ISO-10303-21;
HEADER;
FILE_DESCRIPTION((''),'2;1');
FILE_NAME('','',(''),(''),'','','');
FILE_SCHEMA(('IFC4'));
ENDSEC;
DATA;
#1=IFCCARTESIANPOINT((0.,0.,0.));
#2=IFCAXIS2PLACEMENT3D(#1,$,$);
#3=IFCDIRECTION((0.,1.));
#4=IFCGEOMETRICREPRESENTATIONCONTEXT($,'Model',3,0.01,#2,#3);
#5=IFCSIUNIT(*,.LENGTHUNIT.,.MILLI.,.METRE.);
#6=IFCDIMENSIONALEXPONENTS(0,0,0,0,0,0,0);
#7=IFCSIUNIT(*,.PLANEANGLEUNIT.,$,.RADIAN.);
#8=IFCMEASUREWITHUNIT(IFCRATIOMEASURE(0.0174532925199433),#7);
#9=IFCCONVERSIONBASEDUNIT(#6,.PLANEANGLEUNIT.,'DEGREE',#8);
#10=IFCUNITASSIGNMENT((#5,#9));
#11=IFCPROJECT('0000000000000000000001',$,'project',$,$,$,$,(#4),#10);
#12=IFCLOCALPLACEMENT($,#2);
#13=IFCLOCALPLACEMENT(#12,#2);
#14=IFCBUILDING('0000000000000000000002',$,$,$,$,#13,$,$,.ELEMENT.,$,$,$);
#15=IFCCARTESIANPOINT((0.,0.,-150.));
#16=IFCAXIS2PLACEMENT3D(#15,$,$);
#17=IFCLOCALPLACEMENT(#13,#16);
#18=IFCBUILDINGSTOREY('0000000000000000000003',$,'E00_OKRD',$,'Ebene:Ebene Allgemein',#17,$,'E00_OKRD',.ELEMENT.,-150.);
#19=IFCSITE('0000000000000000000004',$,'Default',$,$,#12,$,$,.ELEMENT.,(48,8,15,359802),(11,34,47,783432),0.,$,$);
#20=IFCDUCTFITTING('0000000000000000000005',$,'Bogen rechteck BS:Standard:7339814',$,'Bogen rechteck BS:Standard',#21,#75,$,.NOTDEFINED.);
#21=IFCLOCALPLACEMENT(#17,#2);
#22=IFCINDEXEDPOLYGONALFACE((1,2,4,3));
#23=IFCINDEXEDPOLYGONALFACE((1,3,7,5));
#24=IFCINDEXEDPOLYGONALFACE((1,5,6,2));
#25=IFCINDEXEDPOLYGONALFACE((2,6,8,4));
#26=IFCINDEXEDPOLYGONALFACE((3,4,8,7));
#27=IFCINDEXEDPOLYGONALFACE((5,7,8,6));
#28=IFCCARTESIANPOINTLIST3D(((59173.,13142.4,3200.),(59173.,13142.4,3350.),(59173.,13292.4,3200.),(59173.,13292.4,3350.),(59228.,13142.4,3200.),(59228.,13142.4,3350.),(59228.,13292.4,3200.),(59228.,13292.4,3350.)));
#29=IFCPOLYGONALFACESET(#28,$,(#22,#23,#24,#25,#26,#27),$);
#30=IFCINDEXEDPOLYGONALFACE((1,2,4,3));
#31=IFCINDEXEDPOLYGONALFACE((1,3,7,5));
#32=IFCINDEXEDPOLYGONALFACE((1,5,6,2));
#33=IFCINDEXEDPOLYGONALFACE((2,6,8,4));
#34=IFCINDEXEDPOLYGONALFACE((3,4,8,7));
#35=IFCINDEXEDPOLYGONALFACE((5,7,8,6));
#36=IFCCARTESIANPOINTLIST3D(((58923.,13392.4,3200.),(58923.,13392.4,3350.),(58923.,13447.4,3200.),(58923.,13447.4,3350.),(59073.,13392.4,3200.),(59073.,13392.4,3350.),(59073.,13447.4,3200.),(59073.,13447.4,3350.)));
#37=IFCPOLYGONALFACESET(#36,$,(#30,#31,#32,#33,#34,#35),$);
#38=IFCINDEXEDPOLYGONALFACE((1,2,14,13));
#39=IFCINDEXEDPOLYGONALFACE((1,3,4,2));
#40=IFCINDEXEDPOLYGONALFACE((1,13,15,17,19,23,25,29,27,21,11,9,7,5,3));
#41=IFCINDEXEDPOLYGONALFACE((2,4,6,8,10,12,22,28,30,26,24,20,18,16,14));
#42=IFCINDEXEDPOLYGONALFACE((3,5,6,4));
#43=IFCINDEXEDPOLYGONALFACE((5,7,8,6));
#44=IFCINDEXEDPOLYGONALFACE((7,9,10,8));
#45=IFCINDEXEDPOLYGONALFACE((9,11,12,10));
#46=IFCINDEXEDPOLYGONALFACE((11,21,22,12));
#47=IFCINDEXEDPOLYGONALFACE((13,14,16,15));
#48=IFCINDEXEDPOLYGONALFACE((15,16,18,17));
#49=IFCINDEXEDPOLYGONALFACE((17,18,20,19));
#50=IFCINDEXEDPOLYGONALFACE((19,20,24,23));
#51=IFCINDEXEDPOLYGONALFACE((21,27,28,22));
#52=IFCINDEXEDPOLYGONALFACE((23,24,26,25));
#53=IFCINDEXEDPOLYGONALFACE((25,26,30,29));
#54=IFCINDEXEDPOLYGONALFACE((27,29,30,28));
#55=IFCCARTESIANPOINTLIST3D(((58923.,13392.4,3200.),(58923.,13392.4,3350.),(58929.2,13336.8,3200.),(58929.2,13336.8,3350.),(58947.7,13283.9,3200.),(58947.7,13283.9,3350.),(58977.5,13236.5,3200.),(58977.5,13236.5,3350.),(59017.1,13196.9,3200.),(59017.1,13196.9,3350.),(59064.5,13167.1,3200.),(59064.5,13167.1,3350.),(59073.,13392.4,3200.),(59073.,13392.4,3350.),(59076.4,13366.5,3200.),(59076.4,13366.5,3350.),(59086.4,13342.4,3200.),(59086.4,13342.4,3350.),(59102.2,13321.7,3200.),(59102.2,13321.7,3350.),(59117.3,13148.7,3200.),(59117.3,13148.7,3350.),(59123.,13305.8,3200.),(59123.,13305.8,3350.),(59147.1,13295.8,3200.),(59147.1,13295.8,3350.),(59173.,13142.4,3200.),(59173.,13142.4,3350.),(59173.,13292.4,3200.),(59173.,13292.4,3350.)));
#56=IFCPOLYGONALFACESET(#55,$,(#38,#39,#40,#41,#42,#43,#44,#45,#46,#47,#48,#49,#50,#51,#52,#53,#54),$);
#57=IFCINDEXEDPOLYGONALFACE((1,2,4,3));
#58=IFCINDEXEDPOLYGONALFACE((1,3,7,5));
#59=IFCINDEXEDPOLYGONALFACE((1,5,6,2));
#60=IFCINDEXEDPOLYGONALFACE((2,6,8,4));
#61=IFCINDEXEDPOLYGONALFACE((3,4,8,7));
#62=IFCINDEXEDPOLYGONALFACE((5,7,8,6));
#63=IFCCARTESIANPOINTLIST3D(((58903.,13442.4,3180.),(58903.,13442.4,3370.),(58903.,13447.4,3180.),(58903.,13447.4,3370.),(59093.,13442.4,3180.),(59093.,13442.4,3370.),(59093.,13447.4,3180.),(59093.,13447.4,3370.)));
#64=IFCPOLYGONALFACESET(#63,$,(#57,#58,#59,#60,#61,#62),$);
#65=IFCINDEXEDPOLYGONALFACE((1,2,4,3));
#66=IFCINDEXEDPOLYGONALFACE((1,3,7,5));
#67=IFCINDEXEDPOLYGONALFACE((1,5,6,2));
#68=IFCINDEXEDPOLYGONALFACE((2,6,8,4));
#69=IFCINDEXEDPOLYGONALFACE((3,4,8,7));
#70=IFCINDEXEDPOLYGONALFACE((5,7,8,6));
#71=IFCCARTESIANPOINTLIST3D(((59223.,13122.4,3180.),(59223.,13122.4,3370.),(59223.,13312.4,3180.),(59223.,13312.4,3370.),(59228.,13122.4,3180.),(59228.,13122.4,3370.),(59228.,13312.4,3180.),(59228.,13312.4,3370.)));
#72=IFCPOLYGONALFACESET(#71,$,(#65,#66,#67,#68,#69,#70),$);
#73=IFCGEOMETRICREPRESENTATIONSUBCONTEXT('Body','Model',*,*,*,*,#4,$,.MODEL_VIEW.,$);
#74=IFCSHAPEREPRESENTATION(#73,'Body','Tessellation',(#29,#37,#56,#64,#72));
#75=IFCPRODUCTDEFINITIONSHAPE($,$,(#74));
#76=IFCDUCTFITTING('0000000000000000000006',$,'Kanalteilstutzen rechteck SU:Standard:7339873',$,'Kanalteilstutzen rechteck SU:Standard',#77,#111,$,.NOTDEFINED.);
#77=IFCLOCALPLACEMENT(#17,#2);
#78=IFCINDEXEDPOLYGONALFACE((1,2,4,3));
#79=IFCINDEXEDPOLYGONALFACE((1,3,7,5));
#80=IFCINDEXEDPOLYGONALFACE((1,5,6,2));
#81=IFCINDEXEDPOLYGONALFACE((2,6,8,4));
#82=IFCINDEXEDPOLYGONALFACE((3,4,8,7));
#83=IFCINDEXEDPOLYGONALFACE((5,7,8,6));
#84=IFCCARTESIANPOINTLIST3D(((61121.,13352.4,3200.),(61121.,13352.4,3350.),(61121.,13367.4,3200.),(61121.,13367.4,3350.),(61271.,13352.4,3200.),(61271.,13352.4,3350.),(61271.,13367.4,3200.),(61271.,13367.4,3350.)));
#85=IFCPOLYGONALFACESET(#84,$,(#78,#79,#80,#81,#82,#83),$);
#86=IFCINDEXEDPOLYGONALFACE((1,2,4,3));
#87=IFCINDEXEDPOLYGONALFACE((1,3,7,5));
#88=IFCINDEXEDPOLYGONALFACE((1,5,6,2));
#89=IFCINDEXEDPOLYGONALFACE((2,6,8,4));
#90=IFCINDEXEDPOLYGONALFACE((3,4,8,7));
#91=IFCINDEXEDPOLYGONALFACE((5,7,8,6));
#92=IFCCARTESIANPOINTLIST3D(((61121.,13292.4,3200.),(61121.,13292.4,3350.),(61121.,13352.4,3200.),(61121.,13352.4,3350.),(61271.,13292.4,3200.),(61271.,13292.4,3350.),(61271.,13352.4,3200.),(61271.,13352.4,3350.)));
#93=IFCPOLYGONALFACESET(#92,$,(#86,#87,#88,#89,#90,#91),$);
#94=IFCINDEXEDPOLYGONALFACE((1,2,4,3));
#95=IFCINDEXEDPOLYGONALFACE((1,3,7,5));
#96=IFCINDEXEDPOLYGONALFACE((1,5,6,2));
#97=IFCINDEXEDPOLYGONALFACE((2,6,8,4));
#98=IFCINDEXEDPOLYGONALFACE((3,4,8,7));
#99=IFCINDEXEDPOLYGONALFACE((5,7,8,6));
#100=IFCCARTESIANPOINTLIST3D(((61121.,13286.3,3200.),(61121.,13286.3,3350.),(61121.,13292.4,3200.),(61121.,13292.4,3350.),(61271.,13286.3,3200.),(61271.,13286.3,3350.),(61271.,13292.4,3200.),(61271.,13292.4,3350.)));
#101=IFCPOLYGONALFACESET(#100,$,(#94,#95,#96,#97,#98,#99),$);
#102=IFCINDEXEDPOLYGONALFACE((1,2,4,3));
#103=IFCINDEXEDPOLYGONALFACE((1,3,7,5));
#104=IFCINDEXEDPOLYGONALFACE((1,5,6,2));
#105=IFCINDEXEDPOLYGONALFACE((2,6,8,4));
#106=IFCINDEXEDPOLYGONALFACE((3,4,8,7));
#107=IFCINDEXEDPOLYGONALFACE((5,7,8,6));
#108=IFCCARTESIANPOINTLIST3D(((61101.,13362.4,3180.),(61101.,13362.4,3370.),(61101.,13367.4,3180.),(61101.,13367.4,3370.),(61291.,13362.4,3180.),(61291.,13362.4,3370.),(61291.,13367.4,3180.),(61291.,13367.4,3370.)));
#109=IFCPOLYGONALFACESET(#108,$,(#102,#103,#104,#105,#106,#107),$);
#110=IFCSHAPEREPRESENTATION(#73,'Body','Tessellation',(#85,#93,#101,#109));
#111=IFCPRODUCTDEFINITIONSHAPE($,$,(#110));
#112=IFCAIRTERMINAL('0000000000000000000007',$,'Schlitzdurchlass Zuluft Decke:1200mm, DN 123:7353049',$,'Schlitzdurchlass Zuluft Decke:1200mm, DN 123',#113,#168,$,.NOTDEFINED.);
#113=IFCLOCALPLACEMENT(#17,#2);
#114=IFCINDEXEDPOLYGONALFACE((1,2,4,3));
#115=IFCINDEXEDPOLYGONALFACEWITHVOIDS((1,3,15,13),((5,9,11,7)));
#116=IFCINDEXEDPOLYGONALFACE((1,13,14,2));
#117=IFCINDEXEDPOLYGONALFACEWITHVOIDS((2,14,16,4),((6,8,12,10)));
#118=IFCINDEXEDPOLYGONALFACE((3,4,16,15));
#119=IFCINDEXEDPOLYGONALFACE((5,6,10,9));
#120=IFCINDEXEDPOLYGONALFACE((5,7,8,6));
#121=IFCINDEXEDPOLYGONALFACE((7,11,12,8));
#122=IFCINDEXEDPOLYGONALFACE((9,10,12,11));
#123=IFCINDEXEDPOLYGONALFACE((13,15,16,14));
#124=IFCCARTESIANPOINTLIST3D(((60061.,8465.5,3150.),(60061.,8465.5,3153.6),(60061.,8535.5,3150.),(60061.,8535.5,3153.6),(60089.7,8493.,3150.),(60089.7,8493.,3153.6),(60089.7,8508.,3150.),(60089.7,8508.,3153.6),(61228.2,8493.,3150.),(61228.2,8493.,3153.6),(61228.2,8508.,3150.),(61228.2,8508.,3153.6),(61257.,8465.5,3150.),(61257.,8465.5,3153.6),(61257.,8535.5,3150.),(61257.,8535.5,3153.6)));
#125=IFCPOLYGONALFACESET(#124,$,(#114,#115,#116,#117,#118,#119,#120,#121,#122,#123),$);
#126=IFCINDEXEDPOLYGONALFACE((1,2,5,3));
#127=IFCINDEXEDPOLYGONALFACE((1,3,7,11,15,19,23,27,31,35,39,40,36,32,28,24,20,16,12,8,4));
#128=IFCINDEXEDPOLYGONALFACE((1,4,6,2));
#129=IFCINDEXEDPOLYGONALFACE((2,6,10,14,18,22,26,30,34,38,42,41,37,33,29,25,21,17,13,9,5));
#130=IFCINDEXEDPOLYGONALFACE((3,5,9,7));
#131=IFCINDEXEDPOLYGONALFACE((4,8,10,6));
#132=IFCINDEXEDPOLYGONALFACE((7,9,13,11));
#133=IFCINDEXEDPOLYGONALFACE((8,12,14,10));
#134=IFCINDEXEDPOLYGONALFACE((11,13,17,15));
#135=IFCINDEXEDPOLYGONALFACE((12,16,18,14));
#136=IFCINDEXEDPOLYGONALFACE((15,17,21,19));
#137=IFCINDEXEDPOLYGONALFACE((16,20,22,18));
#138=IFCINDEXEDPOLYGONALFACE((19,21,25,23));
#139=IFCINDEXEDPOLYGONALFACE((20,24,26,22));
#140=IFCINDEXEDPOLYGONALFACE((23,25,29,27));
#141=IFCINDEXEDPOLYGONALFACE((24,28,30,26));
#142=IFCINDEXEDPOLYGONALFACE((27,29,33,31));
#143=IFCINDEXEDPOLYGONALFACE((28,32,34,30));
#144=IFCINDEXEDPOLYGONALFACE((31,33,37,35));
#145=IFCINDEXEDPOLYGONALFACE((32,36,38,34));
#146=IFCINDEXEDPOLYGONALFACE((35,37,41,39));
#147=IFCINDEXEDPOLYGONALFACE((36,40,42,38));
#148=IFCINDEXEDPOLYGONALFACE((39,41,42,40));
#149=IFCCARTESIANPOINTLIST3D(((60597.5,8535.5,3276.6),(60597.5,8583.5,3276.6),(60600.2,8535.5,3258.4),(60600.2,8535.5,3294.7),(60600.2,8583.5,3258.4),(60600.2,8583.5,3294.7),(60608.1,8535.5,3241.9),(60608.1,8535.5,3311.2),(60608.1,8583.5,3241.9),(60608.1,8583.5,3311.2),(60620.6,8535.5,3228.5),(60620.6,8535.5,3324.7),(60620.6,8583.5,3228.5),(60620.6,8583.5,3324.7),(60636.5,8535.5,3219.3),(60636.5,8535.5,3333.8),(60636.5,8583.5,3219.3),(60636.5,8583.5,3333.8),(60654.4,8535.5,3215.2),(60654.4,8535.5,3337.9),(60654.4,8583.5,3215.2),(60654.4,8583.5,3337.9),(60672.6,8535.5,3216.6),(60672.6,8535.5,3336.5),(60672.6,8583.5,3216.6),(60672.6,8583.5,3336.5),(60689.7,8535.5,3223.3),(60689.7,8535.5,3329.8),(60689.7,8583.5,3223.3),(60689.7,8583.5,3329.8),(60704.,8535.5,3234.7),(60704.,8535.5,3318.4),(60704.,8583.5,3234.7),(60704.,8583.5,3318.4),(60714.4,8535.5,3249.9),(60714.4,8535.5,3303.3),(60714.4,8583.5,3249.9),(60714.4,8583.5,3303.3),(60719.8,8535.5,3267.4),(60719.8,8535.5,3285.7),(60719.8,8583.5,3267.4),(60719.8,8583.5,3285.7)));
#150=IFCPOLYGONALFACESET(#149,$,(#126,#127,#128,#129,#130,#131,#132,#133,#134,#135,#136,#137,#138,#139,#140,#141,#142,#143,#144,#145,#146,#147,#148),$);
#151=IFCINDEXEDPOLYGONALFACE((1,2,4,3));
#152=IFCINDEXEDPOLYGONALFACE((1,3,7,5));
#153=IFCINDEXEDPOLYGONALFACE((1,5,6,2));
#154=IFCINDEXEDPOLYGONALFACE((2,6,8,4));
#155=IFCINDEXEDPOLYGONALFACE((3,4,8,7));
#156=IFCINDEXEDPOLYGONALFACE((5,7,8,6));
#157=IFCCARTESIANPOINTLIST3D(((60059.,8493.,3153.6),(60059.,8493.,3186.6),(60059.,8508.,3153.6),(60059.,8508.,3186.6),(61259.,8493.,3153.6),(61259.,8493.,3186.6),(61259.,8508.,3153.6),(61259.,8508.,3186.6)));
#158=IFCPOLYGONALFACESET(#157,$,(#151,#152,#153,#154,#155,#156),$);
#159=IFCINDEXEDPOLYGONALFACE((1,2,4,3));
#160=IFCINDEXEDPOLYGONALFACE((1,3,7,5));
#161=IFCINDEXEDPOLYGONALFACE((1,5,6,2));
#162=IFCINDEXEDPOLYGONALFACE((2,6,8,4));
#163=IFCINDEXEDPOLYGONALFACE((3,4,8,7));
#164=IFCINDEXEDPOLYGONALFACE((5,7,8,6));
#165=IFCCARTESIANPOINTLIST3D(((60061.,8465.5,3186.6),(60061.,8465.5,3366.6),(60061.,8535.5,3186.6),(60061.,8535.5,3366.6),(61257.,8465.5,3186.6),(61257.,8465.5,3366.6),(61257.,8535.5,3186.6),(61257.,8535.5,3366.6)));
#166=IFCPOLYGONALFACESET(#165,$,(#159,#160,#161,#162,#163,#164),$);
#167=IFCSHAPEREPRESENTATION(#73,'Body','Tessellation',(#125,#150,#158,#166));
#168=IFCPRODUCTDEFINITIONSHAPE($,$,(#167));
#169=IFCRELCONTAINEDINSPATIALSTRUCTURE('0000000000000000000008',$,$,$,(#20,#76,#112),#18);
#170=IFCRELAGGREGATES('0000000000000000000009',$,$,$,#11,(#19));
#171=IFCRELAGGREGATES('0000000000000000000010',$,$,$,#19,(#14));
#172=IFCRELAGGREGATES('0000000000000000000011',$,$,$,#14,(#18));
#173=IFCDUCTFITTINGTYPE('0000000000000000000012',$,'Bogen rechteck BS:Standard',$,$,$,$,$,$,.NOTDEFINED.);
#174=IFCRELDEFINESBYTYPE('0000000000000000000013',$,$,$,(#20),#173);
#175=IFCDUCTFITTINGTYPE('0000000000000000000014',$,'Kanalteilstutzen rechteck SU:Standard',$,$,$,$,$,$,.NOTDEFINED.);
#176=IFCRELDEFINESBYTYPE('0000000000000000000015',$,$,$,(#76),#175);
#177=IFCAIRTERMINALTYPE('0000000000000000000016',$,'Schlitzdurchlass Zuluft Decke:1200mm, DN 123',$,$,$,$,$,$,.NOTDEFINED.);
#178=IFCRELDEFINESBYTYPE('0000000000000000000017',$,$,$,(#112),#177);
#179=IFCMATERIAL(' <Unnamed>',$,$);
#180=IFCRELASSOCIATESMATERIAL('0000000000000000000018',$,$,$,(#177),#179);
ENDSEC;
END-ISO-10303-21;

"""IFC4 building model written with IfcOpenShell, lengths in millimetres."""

from ifc_helpers import new_model, entity, si_unit, converted_unit, direction, frame, frame_2d, origin, origin_2d_with_axis, place, context, subcontext, project, spatial, polyline, circle_curve, parameter, trimmed, segment, composite_curve, rectangle, circle, outline, extrude, source, transform, mapped, material, type_object, type_shapes, element, save


model = new_model("IFC4")

# Units and contexts
model_context = context("Model", 3, precision=0.01, world=origin(), true_north=direction((0.0, 1.0)))
body_context = subcontext(model_context, "Body", "Model", "MODEL_VIEW")
ifc_project = project(units=[si_unit("LENGTHUNIT", "METRE", prefix="MILLI"), converted_unit("PLANEANGLEUNIT", "DEGREE", entity("IfcRatioMeasure", 0.0174532925199433), si_unit("PLANEANGLEUNIT", "RADIAN"), dimensions=[0, 0, 0, 0, 0, 0, 0])], contexts=[model_context])

# Site, building, storey
site_placement = place(None, origin())
site = spatial("IfcSite", under=ifc_project, at=site_placement, Name="Default", CompositionType="ELEMENT", RefLatitude=(48, 8, 15, 359802), RefLongitude=(11, 34, 47, 783432), RefElevation=0.0)
building_placement = place(site_placement, origin())
building = spatial("IfcBuilding", under=site, at=building_placement, CompositionType="ELEMENT")
storey_placement = place(building_placement, frame((0.0, 0.0, -150.0)))
storey = spatial("IfcBuildingStorey", under=building, at=storey_placement, Name="E00_OKRD", ObjectType="Ebene:Ebene Allgemein", LongName="E00_OKRD", CompositionType="ELEMENT", Elevation=-150.0)

# Shared definitions
ifc_material_1 = material(Name=" <Unnamed>")

# Duct fittings
duct_fitting_type_1 = type_object("IfcDuctFittingType", Name="Bogen rechteck BS:Standard", PredefinedType="NOTDEFINED")
shared_shape_1 = source(origin(), body_context, "Body", "SweptSolid", [
    extrude(rectangle(XDim=55.0, YDim=150.0, at=origin_2d_with_axis()), frame((0.0, 202.5, -75.0), z_axis=(0.0, 0.0, 1.0), x_axis=(0.0, 1.0, 0.0)), (0.0, 0.0, 1.0), 150.0),
    extrude(rectangle(XDim=150.0, YDim=55.0, at=frame_2d((0.0, 0.0), x_axis=(1.0, 0.0))), frame((-202.5, 0.0, -75.0), z_axis=(0.0, 0.0, 1.0), x_axis=(0.0, -1.0, 0.0)), (0.0, 0.0, 1.0), 150.0),
    extrude(outline(composite_curve([segment(polyline([(-162.5, -87.5), (-12.5, -87.5)]), True, "CONTINUOUS"), segment(trimmed(circle_curve(frame_2d((87.5, -87.5), x_axis=(0.0, 1.0)), 100.0), [parameter(0.0)], [parameter(90.0)], True, "PARAMETER"), False, "CONTINUOUS"), segment(polyline([(87.5, 12.5), (87.5, 162.5)]), True, "CONTINUOUS"), segment(trimmed(circle_curve(frame_2d((87.5, -87.5), x_axis=(0.0, 1.0)), 250.0), [parameter(0.0)], [parameter(90.0)], True, "PARAMETER"), True, "CONTINUOUS")], self_intersect=False)), frame((-87.5, 87.5, -75.0), z_axis=(0.0, 0.0, 1.0), x_axis=(-1.0, 0.0, 0.0)), (0.0, 0.0, 1.0), 150.0),
    extrude(rectangle(XDim=5.0, YDim=190.0, at=frame_2d((0.0, 0.0), x_axis=(1.0, 0.0))), frame((-227.5, 0.0, -95.0)), (0.0, 0.0, 1.0), 190.0),
    extrude(rectangle(XDim=5.0, YDim=190.0, at=frame_2d((0.0, 0.0), x_axis=(1.0, 0.0))), frame((0.0, 227.5, -95.0), z_axis=(0.0, 0.0, 1.0), x_axis=(0.0, 1.0, 0.0)), (0.0, 0.0, 1.0), 190.0),
])
type_shapes(duct_fitting_type_1, [shared_shape_1])
duct_fitting_1_placement = place(storey_placement, frame((58998.0, 13217.4, 3275.0), z_axis=(0.0, 0.0, 1.0), x_axis=(0.0, -1.0, 0.0)))
element("IfcDuctFitting", 1, at=duct_fitting_1_placement, inside=storey, type_object=duct_fitting_type_1, Name="Bogen rechteck BS:Standard:7339814", ObjectType="Bogen rechteck BS:Standard", PredefinedType="NOTDEFINED", context=body_context, shape_type="MappedRepresentation", body=[
    mapped(shared_shape_1, transform((0.0, 0.0, 0.0), scale=1.0)),
])
duct_fitting_type_2 = type_object("IfcDuctFittingType", Name="Kanalteilstutzen rechteck SU:Standard", PredefinedType="NOTDEFINED")
shared_shape_2 = source(origin(), body_context, "Body", "SweptSolid", [
    extrude(rectangle(XDim=15.0, YDim=150.0, at=frame_2d((0.0, 0.0), x_axis=(1.0, 0.0))), frame((67.5, 0.0, -75.0)), (0.0, 0.0, 1.0), 150.0),
    extrude(rectangle(XDim=60.0, YDim=150.0, at=frame_2d((0.0, 0.0), x_axis=(1.0, 0.0))), frame((30.0, 0.0, -75.0)), (0.0, 0.0, 1.0), 150.0),
    extrude(rectangle(XDim=6.1, YDim=150.0, at=frame_2d((0.0, 0.0), x_axis=(1.0, 0.0))), frame((-3.0, 0.0, -75.0)), (0.0, 0.0, 1.0), 150.0),
    extrude(rectangle(XDim=5.0, YDim=190.0, at=origin_2d_with_axis()), frame((72.5, 0.0, -95.0)), (0.0, 0.0, 1.0), 190.0),
])
type_shapes(duct_fitting_type_2, [shared_shape_2])
duct_fitting_2_placement = place(storey_placement, frame((61196.0, 13292.4, 3275.0), z_axis=(0.0, 0.0, -1.0), x_axis=(0.0, 1.0, 0.0)))
element("IfcDuctFitting", 2, at=duct_fitting_2_placement, inside=storey, type_object=duct_fitting_type_2, Name="Kanalteilstutzen rechteck SU:Standard:7339873", ObjectType="Kanalteilstutzen rechteck SU:Standard", PredefinedType="NOTDEFINED", context=body_context, shape_type="MappedRepresentation", body=[
    mapped(shared_shape_2, transform((0.0, 0.0, 0.0), scale=1.0)),
])

# Air terminal
air_terminal_type_1 = type_object("IfcAirTerminalType", Name="Schlitzdurchlass Zuluft Decke:1200mm, DN 123", PredefinedType="NOTDEFINED", material=ifc_material_1)
shared_shape_3 = source(origin(), body_context, "Body", "SweptSolid", [
    extrude(outline(polyline([(-598.0, -35.0), (598.0, -35.0), (598.0, 35.0), (-598.0, 35.0), (-598.0, -35.0)]), holes=[polyline([(-569.2, -7.5), (-569.2, 7.5), (569.2, 7.5), (569.2, -7.5), (-569.2, -7.5)])]), frame((600.0, 35.0, 0.0), z_axis=(0.0, 0.0, 1.0), x_axis=(-1.0, 0.0, 0.0)), (0.0, 0.0, 1.0), 3.6),
    extrude(circle(Radius=61.5, at=frame_2d((0.0, 0.0), x_axis=(1.0, 0.0))), frame((600.0, 70.0, 126.6), z_axis=(0.0, 1.0, 0.0), x_axis=(-1.0, 0.0, 0.0)), (0.0, 0.0, 1.0), 48.0),
    extrude(rectangle(XDim=1200.0, YDim=15.0, at=origin_2d_with_axis()), frame((600.0, 35.0, 3.6), z_axis=(0.0, 0.0, 1.0), x_axis=(-1.0, 0.0, 0.0)), (0.0, 0.0, 1.0), 33.0),
    extrude(rectangle(XDim=1196.0, YDim=70.0, at=origin_2d_with_axis()), frame((600.0, 35.0, 36.6), z_axis=(0.0, 0.0, 1.0), x_axis=(-1.0, 0.0, 0.0)), (0.0, 0.0, 1.0), 180.0),
])
type_shapes(air_terminal_type_1, [shared_shape_3])
air_terminal_1_placement = place(storey_placement, frame((60059.0, 8465.5, 3150.0)))
element("IfcAirTerminal", 3, at=air_terminal_1_placement, inside=storey, type_object=air_terminal_type_1, Name="Schlitzdurchlass Zuluft Decke:1200mm, DN 123:7353049", ObjectType="Schlitzdurchlass Zuluft Decke:1200mm, DN 123", PredefinedType="NOTDEFINED", context=body_context, shape_type="MappedRepresentation", body=[
    mapped(shared_shape_3, transform((0.0, 0.0, 0.0), scale=1.0)),
])

save(model, "model.ifc")
